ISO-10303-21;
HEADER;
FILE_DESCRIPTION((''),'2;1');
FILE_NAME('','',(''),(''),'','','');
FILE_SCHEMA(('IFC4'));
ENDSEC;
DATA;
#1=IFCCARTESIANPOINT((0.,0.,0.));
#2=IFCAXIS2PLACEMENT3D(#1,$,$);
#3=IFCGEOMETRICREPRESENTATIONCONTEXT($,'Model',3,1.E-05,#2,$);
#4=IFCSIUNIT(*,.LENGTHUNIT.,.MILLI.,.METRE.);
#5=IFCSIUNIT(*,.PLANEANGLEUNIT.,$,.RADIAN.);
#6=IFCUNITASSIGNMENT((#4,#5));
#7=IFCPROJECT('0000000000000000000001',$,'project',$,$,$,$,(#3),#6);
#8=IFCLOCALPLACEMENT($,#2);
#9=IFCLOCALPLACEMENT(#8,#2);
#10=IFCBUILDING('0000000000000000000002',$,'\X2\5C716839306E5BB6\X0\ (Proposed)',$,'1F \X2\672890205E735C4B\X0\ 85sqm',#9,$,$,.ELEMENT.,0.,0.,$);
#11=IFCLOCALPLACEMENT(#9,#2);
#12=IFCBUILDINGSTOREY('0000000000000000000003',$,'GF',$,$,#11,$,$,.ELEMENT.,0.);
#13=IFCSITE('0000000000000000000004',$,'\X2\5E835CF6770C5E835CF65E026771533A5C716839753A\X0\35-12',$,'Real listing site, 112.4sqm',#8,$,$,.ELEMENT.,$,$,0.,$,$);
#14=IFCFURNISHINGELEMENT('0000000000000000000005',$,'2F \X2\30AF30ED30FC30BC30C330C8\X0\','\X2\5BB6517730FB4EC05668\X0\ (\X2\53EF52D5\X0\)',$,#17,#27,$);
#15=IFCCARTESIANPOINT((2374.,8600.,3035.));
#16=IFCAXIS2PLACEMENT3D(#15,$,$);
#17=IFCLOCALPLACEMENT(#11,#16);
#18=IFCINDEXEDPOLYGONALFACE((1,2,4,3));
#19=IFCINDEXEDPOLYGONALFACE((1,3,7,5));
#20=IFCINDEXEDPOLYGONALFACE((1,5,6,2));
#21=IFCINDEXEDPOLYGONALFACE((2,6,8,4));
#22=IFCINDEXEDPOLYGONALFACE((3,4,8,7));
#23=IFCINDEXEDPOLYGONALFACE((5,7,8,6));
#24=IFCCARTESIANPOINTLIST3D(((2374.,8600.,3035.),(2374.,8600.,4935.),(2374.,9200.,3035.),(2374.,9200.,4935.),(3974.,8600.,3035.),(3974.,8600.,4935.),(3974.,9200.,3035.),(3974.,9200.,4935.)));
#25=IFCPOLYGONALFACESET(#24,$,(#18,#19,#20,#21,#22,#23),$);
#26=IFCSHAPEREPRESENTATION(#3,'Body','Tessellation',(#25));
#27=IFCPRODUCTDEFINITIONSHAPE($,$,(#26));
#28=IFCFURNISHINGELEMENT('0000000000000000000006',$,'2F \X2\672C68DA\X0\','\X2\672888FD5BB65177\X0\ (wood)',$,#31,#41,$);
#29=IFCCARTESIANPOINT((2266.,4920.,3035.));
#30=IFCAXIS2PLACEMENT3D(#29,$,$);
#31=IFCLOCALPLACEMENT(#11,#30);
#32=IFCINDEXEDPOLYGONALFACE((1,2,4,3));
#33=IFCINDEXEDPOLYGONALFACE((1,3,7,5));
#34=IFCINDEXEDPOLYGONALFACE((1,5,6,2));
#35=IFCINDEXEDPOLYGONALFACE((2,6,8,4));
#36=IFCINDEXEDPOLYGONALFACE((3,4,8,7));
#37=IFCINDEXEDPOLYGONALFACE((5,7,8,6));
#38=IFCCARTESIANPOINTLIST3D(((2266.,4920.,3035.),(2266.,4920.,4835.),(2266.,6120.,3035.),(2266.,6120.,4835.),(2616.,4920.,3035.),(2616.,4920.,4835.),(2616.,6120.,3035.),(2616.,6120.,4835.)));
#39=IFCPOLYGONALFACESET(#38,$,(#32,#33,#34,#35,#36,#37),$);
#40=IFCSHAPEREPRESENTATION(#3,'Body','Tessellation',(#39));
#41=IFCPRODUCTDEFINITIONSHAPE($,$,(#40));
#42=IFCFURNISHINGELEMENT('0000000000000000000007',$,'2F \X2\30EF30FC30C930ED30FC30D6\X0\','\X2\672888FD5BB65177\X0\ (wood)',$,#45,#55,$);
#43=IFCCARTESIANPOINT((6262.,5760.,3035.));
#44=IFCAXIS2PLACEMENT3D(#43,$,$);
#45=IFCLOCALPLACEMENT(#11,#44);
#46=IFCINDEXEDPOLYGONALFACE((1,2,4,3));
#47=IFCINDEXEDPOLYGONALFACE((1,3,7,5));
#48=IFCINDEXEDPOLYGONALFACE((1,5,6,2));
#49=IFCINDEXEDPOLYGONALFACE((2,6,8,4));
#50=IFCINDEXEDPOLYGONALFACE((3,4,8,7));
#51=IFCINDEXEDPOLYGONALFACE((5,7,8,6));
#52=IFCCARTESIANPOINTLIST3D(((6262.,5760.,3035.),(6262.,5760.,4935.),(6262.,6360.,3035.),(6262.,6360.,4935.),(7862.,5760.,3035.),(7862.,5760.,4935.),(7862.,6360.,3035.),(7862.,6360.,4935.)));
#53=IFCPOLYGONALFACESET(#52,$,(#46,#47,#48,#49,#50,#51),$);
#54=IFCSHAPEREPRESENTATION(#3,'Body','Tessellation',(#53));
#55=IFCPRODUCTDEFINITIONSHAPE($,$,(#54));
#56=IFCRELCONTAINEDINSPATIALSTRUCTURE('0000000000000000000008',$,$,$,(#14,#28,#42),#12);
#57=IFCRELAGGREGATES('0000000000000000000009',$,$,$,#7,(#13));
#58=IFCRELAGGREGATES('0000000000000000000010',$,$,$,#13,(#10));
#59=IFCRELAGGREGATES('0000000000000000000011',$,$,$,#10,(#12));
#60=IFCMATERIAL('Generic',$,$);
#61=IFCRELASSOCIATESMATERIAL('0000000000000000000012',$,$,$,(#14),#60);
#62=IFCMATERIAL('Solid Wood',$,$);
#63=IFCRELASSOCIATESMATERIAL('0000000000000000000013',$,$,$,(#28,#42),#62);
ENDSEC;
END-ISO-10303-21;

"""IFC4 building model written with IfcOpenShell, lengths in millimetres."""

from ifc_helpers import new_model, si_unit, frame, frame_2d, origin, place, context, project, spatial, rectangle, extrude, material, element, save


model = new_model("IFC4")

# Units and contexts
model_context = context("Model", 3, precision=1e-05, world=origin())
ifc_project = project(units=[si_unit("LENGTHUNIT", "METRE", prefix="MILLI"), si_unit("PLANEANGLEUNIT", "RADIAN")], contexts=[model_context])

# Site, building, storey
site_placement = place(None, origin())
site = spatial("IfcSite", under=ifc_project, at=site_placement, Name="広島県広島市東区山根町35-12", ObjectType="Real listing site, 112.4sqm", CompositionType="ELEMENT", RefElevation=0.0)
building_placement = place(site_placement, origin())
building = spatial("IfcBuilding", under=site, at=building_placement, Name="山根の家 (Proposed)", ObjectType="1F 木造平屋 85sqm", CompositionType="ELEMENT", ElevationOfRefHeight=0.0, ElevationOfTerrain=0.0)
storey_placement = place(building_placement, origin())
storey = spatial("IfcBuildingStorey", under=building, at=storey_placement, Name="GF", CompositionType="ELEMENT", Elevation=0.0)

# Shared definitions
ifc_material_1 = material(Name="Solid Wood")

# Shared definitions
ifc_material_2 = material(Name="Generic")

# Furnishing elements
furnishing_1_placement = place(storey_placement, frame((2374.0, 8600.0, 3035.0)))
element("IfcFurnishingElement", 1, at=furnishing_1_placement, inside=storey, material=ifc_material_2, Name="2F クローゼット", Description="家具・什器 (可動)", context=model_context, shape_type="SweptSolid", body=[
    extrude(rectangle(XDim=1600.0, YDim=600.0, at=frame_2d((800.0, 300.0))), frame((2374.0, 8600.0, 3035.0)), (0.0, 0.0, 1.0), 1900.0),
])
furnishing_2_placement = place(storey_placement, frame((2266.0, 4920.0, 3035.0)))
element("IfcFurnishingElement", 2, at=furnishing_2_placement, inside=storey, material=ifc_material_1, Name="2F 本棚", Description="木製家具 (wood)", context=model_context, shape_type="SweptSolid", body=[
    extrude(rectangle(XDim=350.0, YDim=1200.0, at=frame_2d((175.0, 600.0))), frame((2266.0, 4920.0, 3035.0)), (0.0, 0.0, 1.0), 1800.0),
])
furnishing_3_placement = place(storey_placement, frame((6262.0, 5760.0, 3035.0)))
element("IfcFurnishingElement", 3, at=furnishing_3_placement, inside=storey, material=ifc_material_1, Name="2F ワードローブ", Description="木製家具 (wood)", context=model_context, shape_type="SweptSolid", body=[
    extrude(rectangle(XDim=1600.0, YDim=600.0, at=frame_2d((800.0, 300.0))), frame((6262.0, 5760.0, 3035.0)), (0.0, 0.0, 1.0), 1900.0),
])

save(model, "model.ifc")
